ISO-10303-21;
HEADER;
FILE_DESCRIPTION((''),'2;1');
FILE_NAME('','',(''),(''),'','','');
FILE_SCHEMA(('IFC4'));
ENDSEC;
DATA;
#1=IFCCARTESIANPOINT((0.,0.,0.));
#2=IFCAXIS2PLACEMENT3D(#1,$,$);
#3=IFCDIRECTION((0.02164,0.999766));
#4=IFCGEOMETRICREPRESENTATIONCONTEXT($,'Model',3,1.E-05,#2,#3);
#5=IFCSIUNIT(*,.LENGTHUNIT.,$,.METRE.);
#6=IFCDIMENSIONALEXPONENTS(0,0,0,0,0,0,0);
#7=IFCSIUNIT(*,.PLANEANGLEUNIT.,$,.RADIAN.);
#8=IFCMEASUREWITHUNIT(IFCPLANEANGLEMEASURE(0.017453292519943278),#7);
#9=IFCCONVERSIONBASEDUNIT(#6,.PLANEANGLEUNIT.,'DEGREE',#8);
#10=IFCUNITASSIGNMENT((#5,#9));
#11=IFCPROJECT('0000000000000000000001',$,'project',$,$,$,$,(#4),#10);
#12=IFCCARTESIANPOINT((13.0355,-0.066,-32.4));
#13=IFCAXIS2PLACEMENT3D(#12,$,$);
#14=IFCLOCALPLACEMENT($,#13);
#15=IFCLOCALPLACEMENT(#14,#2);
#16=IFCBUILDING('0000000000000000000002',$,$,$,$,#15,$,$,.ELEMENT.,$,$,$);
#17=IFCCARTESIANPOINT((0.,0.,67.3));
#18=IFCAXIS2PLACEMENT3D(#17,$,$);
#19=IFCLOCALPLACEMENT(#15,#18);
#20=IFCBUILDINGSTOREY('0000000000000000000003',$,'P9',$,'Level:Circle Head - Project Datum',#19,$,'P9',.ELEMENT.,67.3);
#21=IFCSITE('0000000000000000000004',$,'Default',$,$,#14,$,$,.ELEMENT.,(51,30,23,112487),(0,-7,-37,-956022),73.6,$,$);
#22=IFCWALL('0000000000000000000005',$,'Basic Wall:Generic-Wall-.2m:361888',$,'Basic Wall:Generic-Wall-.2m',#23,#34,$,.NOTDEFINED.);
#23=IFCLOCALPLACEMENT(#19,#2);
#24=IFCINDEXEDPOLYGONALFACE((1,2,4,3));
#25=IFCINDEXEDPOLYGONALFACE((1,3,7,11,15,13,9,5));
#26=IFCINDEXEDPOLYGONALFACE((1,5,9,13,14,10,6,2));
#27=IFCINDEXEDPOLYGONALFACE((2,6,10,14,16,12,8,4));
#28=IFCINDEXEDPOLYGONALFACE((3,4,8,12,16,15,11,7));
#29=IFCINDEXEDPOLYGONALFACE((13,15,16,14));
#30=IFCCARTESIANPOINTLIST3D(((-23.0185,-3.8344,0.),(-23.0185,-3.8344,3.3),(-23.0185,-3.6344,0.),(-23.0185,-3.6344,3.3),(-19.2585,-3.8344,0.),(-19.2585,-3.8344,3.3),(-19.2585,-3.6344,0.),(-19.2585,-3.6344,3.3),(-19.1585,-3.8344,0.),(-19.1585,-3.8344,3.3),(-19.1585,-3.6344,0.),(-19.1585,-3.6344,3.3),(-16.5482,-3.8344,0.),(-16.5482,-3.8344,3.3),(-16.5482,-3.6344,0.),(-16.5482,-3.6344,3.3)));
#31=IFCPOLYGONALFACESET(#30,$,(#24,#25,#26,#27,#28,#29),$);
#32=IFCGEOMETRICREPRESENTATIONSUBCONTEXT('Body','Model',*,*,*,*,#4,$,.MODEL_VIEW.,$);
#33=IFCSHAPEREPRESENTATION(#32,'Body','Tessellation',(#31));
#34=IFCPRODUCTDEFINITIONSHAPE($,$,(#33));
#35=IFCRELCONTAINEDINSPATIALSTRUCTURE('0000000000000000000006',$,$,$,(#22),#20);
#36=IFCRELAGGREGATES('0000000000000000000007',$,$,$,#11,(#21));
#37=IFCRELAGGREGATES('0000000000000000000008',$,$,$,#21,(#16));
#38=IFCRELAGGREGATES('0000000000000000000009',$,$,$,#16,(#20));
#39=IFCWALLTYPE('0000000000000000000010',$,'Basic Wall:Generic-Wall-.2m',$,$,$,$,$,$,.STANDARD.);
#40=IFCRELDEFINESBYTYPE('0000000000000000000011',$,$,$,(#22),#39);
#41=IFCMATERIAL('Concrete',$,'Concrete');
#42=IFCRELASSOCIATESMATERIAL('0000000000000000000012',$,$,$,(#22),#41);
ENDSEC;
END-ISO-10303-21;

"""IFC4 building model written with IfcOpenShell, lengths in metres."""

from ifc_helpers import new_model, entity, si_unit, converted_unit, direction, frame, origin, place, context, subcontext, project, spatial, indexed_curve, outline, extrude, material, type_object, element, save


model = new_model("IFC4")

# Units and contexts
model_context = context("Model", 3, precision=1e-05, world=origin(), true_north=direction((0.02164, 0.999766)))
body_context = subcontext(model_context, "Body", "Model", "MODEL_VIEW")
ifc_project = project(units=[si_unit("LENGTHUNIT", "METRE"), converted_unit("PLANEANGLEUNIT", "DEGREE", entity("IfcPlaneAngleMeasure", 0.017453292519943278), si_unit("PLANEANGLEUNIT", "RADIAN"), dimensions=[0, 0, 0, 0, 0, 0, 0])], contexts=[model_context])

# Site, building, storey
site_placement = place(None, frame((13.0355, -0.066, -32.4)))
site = spatial("IfcSite", under=ifc_project, at=site_placement, Name="Default", CompositionType="ELEMENT", RefLatitude=(51, 30, 23, 112487), RefLongitude=(0, -7, -37, -956022), RefElevation=73.6)
building_placement = place(site_placement, origin())
building = spatial("IfcBuilding", under=site, at=building_placement, CompositionType="ELEMENT")
storey_placement = place(building_placement, frame((0.0, 0.0, 67.3)))
storey = spatial("IfcBuildingStorey", under=building, at=storey_placement, Name="P9", ObjectType="Level:Circle Head - Project Datum", LongName="P9", CompositionType="ELEMENT", Elevation=67.3)

# Shared definitions
ifc_material = material(Name="Concrete", Category="Concrete")

# Wall
wall_type_1 = type_object("IfcWallType", Name="Basic Wall:Generic-Wall-.2m", PredefinedType="STANDARD")
wall_1_placement = place(storey_placement, frame((-23.0185, -3.7344, 0.0)))
element("IfcWall", 1, at=wall_1_placement, inside=storey, type_object=wall_type_1, material=ifc_material, Name="Basic Wall:Generic-Wall-.2m:361888", ObjectType="Basic Wall:Generic-Wall-.2m", PredefinedType="NOTDEFINED", context=body_context, shape_type="SweptSolid", body=[
    extrude(outline(indexed_curve([(6.4702, -0.1), (6.4702, 0.1), (3.86, 0.1), (3.76, 0.1), (0.0, 0.1), (0.0, -0.1), (3.76, -0.1), (3.86, -0.1), (6.4702, -0.1)], self_intersect=False)), origin(), (0.0, 0.0, 1.0), 3.3),
])

save(model, "model.ifc")
